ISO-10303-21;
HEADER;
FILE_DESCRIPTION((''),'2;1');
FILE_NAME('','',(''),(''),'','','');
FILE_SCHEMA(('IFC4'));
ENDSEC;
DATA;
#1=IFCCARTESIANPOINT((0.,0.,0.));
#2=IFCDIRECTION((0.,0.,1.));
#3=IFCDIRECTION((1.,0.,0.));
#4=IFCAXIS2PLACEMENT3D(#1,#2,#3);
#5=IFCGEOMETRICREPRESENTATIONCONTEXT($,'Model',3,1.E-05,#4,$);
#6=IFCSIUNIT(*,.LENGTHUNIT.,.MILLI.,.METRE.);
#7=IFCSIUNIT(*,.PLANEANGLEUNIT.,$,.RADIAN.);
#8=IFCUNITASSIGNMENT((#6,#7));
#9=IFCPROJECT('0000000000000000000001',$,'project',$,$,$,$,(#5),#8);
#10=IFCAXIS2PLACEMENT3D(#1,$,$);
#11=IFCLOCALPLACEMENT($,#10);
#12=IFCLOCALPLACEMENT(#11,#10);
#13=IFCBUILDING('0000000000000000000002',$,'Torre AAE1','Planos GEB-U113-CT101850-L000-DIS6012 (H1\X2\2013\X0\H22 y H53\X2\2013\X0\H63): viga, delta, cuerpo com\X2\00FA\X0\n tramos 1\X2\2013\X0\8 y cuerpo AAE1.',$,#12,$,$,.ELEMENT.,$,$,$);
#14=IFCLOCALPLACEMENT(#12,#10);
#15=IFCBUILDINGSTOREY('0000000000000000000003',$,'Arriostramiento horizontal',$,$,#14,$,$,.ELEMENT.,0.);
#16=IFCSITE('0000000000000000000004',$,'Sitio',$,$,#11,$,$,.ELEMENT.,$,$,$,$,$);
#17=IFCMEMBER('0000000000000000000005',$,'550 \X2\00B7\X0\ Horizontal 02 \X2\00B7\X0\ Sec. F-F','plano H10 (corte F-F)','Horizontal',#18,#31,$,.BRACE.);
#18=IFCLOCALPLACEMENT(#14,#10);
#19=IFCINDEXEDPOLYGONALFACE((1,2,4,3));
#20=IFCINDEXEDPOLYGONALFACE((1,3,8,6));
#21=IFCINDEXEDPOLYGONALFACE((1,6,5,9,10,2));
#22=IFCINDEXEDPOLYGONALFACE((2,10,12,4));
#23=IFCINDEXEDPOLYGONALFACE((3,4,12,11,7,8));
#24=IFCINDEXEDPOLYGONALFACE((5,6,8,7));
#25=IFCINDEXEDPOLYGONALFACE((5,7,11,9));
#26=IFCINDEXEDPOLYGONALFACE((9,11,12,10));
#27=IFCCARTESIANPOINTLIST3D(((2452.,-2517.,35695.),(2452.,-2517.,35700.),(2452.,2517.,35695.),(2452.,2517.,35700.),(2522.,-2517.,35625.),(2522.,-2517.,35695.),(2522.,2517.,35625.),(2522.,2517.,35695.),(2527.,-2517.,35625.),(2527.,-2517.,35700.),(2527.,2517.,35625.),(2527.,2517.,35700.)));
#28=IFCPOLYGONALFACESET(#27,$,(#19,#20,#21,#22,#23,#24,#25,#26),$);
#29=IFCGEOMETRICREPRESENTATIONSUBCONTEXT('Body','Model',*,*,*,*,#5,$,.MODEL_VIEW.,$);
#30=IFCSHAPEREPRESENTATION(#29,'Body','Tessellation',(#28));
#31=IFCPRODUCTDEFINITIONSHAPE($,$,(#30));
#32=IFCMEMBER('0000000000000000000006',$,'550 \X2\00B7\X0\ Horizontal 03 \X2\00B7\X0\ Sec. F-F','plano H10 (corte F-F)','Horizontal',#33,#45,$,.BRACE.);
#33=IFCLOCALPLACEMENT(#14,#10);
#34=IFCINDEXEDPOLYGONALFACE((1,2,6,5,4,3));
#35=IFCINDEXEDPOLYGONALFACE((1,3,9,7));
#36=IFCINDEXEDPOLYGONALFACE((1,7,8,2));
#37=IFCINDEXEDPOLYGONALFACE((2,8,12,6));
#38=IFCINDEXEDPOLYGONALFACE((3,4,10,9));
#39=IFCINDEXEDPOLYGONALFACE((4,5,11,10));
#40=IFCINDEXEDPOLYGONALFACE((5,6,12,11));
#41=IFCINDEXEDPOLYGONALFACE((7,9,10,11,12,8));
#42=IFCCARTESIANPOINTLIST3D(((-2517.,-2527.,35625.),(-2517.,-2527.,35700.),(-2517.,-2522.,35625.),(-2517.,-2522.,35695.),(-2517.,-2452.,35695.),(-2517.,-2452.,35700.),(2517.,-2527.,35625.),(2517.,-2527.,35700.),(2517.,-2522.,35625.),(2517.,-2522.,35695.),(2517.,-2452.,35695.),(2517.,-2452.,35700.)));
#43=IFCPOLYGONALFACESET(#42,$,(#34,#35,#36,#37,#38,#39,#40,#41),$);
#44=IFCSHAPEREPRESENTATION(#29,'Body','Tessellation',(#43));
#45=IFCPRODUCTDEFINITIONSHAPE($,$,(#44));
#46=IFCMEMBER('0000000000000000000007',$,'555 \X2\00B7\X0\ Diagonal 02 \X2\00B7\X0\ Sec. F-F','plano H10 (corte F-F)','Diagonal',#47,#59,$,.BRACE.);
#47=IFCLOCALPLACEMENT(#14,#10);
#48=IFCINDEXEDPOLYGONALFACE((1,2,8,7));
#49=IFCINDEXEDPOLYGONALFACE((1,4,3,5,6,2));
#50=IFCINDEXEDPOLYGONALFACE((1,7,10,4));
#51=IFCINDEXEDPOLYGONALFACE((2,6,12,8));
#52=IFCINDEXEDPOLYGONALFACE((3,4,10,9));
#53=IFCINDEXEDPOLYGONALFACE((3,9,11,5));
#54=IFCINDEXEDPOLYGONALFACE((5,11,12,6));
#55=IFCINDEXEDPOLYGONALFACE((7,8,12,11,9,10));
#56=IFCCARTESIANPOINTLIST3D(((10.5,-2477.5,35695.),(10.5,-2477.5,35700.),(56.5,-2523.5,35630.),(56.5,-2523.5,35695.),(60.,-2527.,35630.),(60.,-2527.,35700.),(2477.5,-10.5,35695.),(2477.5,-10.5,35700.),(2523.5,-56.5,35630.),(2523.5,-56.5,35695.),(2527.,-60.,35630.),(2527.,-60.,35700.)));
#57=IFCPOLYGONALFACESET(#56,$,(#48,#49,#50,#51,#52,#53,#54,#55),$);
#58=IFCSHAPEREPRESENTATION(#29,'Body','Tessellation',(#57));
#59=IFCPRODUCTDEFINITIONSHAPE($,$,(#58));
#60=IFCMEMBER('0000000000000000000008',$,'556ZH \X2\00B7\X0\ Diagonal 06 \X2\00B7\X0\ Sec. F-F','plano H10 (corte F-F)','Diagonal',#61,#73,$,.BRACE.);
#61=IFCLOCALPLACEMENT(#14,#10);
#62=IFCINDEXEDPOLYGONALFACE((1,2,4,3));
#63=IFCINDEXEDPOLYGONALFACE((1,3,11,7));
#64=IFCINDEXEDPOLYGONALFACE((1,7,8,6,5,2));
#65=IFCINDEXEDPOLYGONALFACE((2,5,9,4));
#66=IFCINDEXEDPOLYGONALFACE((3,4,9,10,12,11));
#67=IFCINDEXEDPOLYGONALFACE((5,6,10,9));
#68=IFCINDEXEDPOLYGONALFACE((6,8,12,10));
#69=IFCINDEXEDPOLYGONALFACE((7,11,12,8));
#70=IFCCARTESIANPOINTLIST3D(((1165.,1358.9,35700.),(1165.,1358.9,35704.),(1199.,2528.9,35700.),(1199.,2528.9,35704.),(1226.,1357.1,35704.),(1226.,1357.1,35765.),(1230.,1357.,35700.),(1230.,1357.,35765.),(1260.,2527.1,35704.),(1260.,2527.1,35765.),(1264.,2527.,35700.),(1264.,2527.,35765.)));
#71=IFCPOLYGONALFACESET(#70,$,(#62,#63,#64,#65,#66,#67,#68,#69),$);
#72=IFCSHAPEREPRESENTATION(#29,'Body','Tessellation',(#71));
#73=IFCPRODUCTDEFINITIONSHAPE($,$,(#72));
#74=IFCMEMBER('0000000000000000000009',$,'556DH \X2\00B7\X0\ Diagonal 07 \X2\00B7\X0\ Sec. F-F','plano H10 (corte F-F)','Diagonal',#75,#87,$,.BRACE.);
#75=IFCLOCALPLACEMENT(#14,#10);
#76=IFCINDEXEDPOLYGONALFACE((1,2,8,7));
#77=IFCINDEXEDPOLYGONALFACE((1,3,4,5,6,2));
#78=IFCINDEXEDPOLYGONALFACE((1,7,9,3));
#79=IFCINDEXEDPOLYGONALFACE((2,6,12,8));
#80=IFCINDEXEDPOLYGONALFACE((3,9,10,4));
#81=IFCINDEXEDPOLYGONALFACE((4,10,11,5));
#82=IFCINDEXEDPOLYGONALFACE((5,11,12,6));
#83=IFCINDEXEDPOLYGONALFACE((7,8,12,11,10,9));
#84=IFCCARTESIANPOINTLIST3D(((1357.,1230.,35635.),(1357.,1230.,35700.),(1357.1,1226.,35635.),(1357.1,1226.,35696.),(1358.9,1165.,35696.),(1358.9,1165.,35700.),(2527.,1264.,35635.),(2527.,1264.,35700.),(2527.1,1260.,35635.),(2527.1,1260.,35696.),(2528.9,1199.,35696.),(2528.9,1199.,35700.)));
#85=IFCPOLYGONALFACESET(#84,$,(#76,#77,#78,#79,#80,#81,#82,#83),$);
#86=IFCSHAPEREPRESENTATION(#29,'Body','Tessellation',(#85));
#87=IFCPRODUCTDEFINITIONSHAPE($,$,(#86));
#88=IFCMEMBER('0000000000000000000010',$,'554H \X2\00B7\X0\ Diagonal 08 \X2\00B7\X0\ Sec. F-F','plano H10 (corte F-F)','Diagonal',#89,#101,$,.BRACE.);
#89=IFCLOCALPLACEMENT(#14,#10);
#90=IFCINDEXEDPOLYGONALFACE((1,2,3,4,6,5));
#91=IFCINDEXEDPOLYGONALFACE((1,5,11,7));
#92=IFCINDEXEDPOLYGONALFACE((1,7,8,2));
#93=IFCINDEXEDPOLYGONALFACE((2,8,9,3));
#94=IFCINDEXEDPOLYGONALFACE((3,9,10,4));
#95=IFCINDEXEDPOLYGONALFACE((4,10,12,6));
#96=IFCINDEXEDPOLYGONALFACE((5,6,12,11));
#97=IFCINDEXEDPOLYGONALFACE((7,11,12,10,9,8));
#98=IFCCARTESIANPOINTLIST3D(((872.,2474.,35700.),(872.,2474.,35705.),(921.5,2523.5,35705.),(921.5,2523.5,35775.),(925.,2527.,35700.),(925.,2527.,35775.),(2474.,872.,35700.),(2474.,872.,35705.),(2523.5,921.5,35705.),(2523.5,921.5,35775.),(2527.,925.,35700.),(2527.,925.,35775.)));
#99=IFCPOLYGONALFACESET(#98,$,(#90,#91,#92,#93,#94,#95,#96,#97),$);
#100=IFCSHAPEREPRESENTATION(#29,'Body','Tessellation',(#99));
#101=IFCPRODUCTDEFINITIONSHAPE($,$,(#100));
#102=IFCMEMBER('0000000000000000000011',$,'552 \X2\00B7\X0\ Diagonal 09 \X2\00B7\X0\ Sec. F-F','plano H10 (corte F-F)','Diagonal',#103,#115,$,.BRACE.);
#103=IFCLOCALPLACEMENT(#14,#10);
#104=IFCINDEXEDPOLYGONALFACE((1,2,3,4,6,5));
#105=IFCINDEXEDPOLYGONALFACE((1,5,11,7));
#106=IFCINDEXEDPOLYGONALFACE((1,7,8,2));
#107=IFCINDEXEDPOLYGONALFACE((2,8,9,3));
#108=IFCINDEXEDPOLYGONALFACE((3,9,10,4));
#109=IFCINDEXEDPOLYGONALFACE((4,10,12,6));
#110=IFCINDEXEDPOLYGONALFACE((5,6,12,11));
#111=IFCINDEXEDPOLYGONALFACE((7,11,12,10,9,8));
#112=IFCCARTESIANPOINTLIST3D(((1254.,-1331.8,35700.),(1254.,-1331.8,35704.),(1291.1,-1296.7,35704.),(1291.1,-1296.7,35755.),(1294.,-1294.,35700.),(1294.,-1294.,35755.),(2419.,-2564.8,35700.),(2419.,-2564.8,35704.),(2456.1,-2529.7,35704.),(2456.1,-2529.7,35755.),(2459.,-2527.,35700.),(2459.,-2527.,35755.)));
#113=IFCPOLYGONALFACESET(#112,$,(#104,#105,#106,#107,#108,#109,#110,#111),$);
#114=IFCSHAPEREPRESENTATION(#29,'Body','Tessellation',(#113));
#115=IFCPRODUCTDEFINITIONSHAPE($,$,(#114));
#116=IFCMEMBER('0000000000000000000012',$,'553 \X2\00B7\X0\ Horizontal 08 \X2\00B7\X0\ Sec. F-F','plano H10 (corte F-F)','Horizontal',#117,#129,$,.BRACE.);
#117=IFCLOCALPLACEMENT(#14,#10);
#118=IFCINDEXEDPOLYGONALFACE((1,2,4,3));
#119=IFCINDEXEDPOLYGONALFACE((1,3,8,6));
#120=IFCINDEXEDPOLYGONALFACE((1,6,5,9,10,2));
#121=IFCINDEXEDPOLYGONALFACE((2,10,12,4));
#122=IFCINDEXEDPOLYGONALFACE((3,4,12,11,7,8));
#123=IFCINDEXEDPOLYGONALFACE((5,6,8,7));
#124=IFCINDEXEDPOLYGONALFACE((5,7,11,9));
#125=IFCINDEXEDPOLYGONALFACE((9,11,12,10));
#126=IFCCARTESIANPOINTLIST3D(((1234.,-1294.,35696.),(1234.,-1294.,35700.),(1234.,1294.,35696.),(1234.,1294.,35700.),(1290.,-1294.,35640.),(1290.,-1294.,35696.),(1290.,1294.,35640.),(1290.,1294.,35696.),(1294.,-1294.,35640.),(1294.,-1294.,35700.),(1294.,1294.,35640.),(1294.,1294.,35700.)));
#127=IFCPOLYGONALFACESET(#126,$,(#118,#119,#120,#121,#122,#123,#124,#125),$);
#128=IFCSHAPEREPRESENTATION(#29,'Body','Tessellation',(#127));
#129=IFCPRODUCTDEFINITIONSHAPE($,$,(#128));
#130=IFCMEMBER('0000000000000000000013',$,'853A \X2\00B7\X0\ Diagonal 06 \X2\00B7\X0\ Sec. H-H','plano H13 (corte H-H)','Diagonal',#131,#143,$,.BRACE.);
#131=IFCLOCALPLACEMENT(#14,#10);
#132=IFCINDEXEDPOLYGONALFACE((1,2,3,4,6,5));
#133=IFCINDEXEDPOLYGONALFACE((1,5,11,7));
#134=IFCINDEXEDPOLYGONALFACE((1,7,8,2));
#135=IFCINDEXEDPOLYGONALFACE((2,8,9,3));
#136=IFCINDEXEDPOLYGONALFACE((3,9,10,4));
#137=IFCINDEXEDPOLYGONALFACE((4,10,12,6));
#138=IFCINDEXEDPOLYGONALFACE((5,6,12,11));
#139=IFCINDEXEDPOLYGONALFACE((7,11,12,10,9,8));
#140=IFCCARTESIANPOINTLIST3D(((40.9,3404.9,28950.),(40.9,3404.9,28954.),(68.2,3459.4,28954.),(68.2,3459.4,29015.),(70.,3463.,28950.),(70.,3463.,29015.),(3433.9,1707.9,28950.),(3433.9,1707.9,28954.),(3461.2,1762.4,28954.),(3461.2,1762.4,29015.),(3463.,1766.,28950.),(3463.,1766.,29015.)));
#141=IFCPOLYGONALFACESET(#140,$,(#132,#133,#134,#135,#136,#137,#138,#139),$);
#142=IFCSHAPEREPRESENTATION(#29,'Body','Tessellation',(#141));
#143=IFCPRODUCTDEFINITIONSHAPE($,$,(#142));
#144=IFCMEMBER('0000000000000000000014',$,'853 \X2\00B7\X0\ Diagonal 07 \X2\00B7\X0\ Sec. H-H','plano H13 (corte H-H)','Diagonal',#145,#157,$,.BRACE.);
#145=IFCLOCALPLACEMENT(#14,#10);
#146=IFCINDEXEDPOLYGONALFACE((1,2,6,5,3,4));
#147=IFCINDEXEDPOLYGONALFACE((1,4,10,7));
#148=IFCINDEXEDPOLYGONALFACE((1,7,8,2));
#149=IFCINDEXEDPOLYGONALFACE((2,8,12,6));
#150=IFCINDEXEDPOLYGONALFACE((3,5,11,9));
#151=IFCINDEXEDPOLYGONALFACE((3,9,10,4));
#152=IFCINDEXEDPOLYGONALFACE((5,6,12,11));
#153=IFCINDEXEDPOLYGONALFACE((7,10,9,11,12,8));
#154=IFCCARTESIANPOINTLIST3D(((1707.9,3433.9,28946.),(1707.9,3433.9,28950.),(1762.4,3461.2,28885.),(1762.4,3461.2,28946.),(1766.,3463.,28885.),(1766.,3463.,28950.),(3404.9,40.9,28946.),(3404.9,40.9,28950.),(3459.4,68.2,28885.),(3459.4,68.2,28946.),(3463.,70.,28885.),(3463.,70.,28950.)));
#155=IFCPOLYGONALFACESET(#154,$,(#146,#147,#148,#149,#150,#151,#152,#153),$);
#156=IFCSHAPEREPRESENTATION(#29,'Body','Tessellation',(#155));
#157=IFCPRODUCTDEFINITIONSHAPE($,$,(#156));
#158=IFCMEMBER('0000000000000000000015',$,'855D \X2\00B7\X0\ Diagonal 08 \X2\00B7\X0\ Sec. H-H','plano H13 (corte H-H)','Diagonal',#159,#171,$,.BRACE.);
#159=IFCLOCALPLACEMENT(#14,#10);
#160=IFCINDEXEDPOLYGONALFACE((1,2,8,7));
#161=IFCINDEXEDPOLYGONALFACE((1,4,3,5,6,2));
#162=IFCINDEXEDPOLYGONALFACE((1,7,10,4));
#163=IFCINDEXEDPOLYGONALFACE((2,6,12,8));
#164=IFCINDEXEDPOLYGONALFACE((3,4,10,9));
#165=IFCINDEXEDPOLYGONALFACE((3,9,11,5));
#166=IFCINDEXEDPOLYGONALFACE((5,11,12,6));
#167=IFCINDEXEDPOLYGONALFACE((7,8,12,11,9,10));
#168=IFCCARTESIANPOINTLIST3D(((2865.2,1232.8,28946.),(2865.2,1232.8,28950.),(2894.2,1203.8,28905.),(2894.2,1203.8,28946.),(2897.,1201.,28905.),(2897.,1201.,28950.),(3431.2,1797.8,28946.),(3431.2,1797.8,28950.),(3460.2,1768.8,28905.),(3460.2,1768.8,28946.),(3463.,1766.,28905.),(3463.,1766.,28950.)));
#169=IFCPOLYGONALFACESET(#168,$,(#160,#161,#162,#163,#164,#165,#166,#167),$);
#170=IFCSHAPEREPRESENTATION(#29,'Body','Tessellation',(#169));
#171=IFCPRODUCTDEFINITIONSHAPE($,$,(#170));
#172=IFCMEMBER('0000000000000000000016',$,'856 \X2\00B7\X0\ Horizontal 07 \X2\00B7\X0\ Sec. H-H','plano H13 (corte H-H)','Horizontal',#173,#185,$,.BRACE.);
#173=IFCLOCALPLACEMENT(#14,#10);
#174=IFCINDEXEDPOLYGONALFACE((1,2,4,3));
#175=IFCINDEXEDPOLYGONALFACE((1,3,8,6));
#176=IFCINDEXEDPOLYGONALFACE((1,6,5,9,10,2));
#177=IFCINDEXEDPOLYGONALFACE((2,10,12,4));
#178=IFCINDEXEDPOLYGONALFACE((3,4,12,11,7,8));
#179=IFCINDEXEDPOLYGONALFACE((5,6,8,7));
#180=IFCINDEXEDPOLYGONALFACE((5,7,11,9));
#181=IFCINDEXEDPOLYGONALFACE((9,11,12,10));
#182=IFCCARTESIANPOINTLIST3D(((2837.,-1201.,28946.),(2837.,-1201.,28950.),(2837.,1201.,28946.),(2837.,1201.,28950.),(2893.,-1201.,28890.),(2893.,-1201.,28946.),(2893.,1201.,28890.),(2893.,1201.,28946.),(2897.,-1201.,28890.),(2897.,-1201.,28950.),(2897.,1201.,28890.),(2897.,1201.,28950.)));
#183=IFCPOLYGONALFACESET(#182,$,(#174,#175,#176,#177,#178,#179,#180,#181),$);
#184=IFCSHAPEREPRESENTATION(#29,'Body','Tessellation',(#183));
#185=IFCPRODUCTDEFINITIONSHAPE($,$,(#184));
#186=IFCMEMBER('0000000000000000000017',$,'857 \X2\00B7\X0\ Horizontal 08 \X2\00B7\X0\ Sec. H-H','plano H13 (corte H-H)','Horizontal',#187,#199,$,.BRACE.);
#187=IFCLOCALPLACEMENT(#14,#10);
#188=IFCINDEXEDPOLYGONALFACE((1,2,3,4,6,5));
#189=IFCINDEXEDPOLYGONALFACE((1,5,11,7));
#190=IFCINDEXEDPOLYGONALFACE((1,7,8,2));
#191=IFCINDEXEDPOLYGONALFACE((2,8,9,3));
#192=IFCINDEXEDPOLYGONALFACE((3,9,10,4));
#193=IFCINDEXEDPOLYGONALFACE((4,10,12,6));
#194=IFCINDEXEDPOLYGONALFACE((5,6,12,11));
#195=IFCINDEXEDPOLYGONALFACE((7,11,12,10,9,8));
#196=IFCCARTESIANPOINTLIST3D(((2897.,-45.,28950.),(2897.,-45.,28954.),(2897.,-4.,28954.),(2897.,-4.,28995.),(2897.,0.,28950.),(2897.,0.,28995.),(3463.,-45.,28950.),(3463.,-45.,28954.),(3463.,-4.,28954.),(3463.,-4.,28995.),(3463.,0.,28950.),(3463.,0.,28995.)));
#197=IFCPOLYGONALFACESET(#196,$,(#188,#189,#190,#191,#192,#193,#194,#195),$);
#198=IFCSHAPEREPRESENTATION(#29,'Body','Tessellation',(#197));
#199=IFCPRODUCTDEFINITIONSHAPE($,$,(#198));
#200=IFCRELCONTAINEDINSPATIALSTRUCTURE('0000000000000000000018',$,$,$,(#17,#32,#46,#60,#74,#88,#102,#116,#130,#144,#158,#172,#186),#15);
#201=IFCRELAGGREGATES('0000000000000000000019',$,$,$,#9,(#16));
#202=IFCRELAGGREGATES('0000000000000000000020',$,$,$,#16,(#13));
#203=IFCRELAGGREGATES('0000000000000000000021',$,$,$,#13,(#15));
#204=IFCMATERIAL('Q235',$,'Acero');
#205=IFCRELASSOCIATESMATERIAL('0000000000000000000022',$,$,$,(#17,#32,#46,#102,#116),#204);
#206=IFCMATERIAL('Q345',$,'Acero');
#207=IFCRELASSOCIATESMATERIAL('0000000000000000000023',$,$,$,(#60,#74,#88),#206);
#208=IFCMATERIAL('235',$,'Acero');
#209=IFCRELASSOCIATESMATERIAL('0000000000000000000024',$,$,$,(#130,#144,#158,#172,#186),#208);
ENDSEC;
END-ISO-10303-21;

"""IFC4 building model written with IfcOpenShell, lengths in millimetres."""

from ifc_helpers import new_model, si_unit, frame, frame_2d, origin, origin_with_axes, place, context, subcontext, project, spatial, l_section, extrude, material, element, save


model = new_model("IFC4")

# Units and contexts
model_context = context("Model", 3, precision=1e-05, world=origin_with_axes())
body_context = subcontext(model_context, "Body", "Model", "MODEL_VIEW")
ifc_project = project(units=[si_unit("LENGTHUNIT", "METRE", prefix="MILLI"), si_unit("PLANEANGLEUNIT", "RADIAN")], contexts=[model_context])

# Site, building, storey
site_placement = place(None, origin())
site = spatial("IfcSite", under=ifc_project, at=site_placement, Name="Sitio", CompositionType="ELEMENT")
building_placement = place(site_placement, origin())
building = spatial("IfcBuilding", under=site, at=building_placement, Name="Torre AAE1", Description="Planos GEB-U113-CT101850-L000-DIS6012 (H1–H22 y H53–H63): viga, delta, cuerpo común tramos 1–8 y cuerpo AAE1.", CompositionType="ELEMENT")
storey_placement = place(building_placement, origin())
storey = spatial("IfcBuildingStorey", under=building, at=storey_placement, Name="Arriostramiento horizontal", CompositionType="ELEMENT", Elevation=0.0)

# Members
ifc_material_1 = material(Name="Q235", Category="Acero")
for number, where, z_axis, x_axis, name in (
    (1, (2527.0, 2517.0, 35700.0), (0.0, -1.0, 0.0), (-1.0, 0.0, 0.0), "550 · Horizontal 02 · Sec. F-F"),
    (2, (2517.0, -2527.0, 35700.0), (-1.0, 0.0, 0.0), (0.0, 1.0, 0.0), "550 · Horizontal 03 · Sec. F-F"),
):
    element("IfcMember", number, at=place(storey_placement, frame(where, z_axis=z_axis, x_axis=x_axis)), inside=storey, material=ifc_material_1, Name=name, Description="plano H10 (corte F-F)", ObjectType="Horizontal", PredefinedType="BRACE", context=body_context, shape_type="SweptSolid", body=[
        extrude(l_section(Depth=75.0, Width=75.0, Thickness=5.0, at=frame_2d((37.5, 37.5))), None, (0.0, 0.0, 1.0), 5034.0),
    ])
member_1_placement = place(storey_placement, frame((2527.0, -60.0, 35700.0), z_axis=(-0.707107, -0.707107, 0.0), x_axis=(-0.707107, 0.707107, 0.0)))
element("IfcMember", 3, at=member_1_placement, inside=storey, material=ifc_material_1, Name="555 · Diagonal 02 · Sec. F-F", Description="plano H10 (corte F-F)", ObjectType="Diagonal", PredefinedType="BRACE", context=body_context, shape_type="SweptSolid", body=[
    extrude(l_section(Depth=70.0, Width=70.0, Thickness=5.0, at=frame_2d((35.0, 35.0))), None, (0.0, 0.0, 1.0), 3488.9),
])
ifc_material_2 = material(Name="Q345", Category="Acero")
for number, where, z_axis, x_axis, name in (
    (4, (1230.0, 1357.0, 35700.0), (0.029048, 0.999578, 0.0), (-0.999578, 0.029048, 0.0), "556ZH · Diagonal 06 · Sec. F-F"),
    (5, (1357.0, 1230.0, 35700.0), (0.999578, 0.029048, 0.0), (0.029048, -0.999578, 0.0), "556DH · Diagonal 07 · Sec. F-F"),
):
    element("IfcMember", number, at=place(storey_placement, frame(where, z_axis=z_axis, x_axis=x_axis)), inside=storey, material=ifc_material_2, Name=name, Description="plano H10 (corte F-F)", ObjectType="Diagonal", PredefinedType="BRACE", context=body_context, shape_type="SweptSolid", body=[
        extrude(l_section(Depth=65.0, Width=65.0, Thickness=4.0, at=frame_2d((32.5, 32.5))), None, (0.0, 0.0, 1.0), 1170.5),
    ])
member_2_placement = place(storey_placement, frame((2527.0, 925.0, 35700.0), z_axis=(-0.707107, 0.707107, 0.0), x_axis=(-0.707107, -0.707107, 0.0)))
element("IfcMember", 6, at=member_2_placement, inside=storey, material=ifc_material_2, Name="554H · Diagonal 08 · Sec. F-F", Description="plano H10 (corte F-F)", ObjectType="Diagonal", PredefinedType="BRACE", context=body_context, shape_type="SweptSolid", body=[
    extrude(l_section(Depth=75.0, Width=75.0, Thickness=5.0, at=frame_2d((37.5, 37.5))), None, (0.0, 0.0, 1.0), 2265.6),
])
member_3_placement = place(storey_placement, frame((2459.0, -2527.0, 35700.0), z_axis=(-0.686779, 0.726866, 0.0), x_axis=(-0.726866, -0.686779, 0.0)))
element("IfcMember", 7, at=member_3_placement, inside=storey, material=ifc_material_1, Name="552 · Diagonal 09 · Sec. F-F", Description="plano H10 (corte F-F)", ObjectType="Diagonal", PredefinedType="BRACE", context=body_context, shape_type="SweptSolid", body=[
    extrude(l_section(Depth=55.0, Width=55.0, Thickness=4.0, at=frame_2d((27.5, 27.5))), None, (0.0, 0.0, 1.0), 1696.3),
])
member_4_placement = place(storey_placement, frame((1294.0, 1294.0, 35700.0), z_axis=(0.0, -1.0, 0.0), x_axis=(-1.0, 0.0, 0.0)))
element("IfcMember", 8, at=member_4_placement, inside=storey, material=ifc_material_1, Name="553 · Horizontal 08 · Sec. F-F", Description="plano H10 (corte F-F)", ObjectType="Horizontal", PredefinedType="BRACE", context=body_context, shape_type="SweptSolid", body=[
    extrude(l_section(Depth=60.0, Width=60.0, Thickness=4.0, at=frame_2d((30.0, 30.0))), None, (0.0, 0.0, 1.0), 2588.0),
])
ifc_material_3 = material(Name="235", Category="Acero")
for number, where, z_axis, x_axis, name in (
    (9, (3463.0, 1766.0, 28950.0), (-0.894374, 0.447319, 0.0), (-0.447319, -0.894374, 0.0), "853A · Diagonal 06 · Sec. H-H"),
    (10, (1766.0, 3463.0, 28950.0), (0.447319, -0.894374, 0.0), (-0.894374, -0.447319, 0.0), "853 · Diagonal 07 · Sec. H-H"),
):
    element("IfcMember", number, at=place(storey_placement, frame(where, z_axis=z_axis, x_axis=x_axis)), inside=storey, material=ifc_material_3, Name=name, Description="plano H13 (corte H-H)", ObjectType="Diagonal", PredefinedType="BRACE", context=body_context, shape_type="SweptSolid", body=[
        extrude(l_section(Depth=65.0, Width=65.0, Thickness=4.0, at=frame_2d((32.5, 32.5))), None, (0.0, 0.0, 1.0), 3793.7),
    ])
member_5_placement = place(storey_placement, frame((3463.0, 1766.0, 28950.0), z_axis=(-0.707732, -0.706481, 0.0), x_axis=(-0.706481, 0.707732, 0.0)))
element("IfcMember", 11, at=member_5_placement, inside=storey, material=ifc_material_3, Name="855D · Diagonal 08 · Sec. H-H", Description="plano H13 (corte H-H)", ObjectType="Diagonal", PredefinedType="BRACE", context=body_context, shape_type="SweptSolid", body=[
    extrude(l_section(Depth=45.0, Width=45.0, Thickness=4.0, at=frame_2d((22.5, 22.5))), None, (0.0, 0.0, 1.0), 799.7),
])
member_6_placement = place(storey_placement, frame((2897.0, 1201.0, 28950.0), z_axis=(0.0, -1.0, 0.0), x_axis=(-1.0, 0.0, 0.0)))
element("IfcMember", 12, at=member_6_placement, inside=storey, material=ifc_material_3, Name="856 · Horizontal 07 · Sec. H-H", Description="plano H13 (corte H-H)", ObjectType="Horizontal", PredefinedType="BRACE", context=body_context, shape_type="SweptSolid", body=[
    extrude(l_section(Depth=60.0, Width=60.0, Thickness=4.0, at=frame_2d((30.0, 30.0))), None, (0.0, 0.0, 1.0), 2402.0),
])
member_7_placement = place(storey_placement, frame((2897.0, 0.0, 28950.0), z_axis=(1.0, 0.0, 0.0), x_axis=(0.0, 0.0, 1.0)))
element("IfcMember", 13, at=member_7_placement, inside=storey, material=ifc_material_3, Name="857 · Horizontal 08 · Sec. H-H", Description="plano H13 (corte H-H)", ObjectType="Horizontal", PredefinedType="BRACE", context=body_context, shape_type="SweptSolid", body=[
    extrude(l_section(Depth=45.0, Width=45.0, Thickness=4.0, at=frame_2d((22.5, 22.5))), None, (0.0, 0.0, 1.0), 566.0),
])

save(model, "model.ifc")
